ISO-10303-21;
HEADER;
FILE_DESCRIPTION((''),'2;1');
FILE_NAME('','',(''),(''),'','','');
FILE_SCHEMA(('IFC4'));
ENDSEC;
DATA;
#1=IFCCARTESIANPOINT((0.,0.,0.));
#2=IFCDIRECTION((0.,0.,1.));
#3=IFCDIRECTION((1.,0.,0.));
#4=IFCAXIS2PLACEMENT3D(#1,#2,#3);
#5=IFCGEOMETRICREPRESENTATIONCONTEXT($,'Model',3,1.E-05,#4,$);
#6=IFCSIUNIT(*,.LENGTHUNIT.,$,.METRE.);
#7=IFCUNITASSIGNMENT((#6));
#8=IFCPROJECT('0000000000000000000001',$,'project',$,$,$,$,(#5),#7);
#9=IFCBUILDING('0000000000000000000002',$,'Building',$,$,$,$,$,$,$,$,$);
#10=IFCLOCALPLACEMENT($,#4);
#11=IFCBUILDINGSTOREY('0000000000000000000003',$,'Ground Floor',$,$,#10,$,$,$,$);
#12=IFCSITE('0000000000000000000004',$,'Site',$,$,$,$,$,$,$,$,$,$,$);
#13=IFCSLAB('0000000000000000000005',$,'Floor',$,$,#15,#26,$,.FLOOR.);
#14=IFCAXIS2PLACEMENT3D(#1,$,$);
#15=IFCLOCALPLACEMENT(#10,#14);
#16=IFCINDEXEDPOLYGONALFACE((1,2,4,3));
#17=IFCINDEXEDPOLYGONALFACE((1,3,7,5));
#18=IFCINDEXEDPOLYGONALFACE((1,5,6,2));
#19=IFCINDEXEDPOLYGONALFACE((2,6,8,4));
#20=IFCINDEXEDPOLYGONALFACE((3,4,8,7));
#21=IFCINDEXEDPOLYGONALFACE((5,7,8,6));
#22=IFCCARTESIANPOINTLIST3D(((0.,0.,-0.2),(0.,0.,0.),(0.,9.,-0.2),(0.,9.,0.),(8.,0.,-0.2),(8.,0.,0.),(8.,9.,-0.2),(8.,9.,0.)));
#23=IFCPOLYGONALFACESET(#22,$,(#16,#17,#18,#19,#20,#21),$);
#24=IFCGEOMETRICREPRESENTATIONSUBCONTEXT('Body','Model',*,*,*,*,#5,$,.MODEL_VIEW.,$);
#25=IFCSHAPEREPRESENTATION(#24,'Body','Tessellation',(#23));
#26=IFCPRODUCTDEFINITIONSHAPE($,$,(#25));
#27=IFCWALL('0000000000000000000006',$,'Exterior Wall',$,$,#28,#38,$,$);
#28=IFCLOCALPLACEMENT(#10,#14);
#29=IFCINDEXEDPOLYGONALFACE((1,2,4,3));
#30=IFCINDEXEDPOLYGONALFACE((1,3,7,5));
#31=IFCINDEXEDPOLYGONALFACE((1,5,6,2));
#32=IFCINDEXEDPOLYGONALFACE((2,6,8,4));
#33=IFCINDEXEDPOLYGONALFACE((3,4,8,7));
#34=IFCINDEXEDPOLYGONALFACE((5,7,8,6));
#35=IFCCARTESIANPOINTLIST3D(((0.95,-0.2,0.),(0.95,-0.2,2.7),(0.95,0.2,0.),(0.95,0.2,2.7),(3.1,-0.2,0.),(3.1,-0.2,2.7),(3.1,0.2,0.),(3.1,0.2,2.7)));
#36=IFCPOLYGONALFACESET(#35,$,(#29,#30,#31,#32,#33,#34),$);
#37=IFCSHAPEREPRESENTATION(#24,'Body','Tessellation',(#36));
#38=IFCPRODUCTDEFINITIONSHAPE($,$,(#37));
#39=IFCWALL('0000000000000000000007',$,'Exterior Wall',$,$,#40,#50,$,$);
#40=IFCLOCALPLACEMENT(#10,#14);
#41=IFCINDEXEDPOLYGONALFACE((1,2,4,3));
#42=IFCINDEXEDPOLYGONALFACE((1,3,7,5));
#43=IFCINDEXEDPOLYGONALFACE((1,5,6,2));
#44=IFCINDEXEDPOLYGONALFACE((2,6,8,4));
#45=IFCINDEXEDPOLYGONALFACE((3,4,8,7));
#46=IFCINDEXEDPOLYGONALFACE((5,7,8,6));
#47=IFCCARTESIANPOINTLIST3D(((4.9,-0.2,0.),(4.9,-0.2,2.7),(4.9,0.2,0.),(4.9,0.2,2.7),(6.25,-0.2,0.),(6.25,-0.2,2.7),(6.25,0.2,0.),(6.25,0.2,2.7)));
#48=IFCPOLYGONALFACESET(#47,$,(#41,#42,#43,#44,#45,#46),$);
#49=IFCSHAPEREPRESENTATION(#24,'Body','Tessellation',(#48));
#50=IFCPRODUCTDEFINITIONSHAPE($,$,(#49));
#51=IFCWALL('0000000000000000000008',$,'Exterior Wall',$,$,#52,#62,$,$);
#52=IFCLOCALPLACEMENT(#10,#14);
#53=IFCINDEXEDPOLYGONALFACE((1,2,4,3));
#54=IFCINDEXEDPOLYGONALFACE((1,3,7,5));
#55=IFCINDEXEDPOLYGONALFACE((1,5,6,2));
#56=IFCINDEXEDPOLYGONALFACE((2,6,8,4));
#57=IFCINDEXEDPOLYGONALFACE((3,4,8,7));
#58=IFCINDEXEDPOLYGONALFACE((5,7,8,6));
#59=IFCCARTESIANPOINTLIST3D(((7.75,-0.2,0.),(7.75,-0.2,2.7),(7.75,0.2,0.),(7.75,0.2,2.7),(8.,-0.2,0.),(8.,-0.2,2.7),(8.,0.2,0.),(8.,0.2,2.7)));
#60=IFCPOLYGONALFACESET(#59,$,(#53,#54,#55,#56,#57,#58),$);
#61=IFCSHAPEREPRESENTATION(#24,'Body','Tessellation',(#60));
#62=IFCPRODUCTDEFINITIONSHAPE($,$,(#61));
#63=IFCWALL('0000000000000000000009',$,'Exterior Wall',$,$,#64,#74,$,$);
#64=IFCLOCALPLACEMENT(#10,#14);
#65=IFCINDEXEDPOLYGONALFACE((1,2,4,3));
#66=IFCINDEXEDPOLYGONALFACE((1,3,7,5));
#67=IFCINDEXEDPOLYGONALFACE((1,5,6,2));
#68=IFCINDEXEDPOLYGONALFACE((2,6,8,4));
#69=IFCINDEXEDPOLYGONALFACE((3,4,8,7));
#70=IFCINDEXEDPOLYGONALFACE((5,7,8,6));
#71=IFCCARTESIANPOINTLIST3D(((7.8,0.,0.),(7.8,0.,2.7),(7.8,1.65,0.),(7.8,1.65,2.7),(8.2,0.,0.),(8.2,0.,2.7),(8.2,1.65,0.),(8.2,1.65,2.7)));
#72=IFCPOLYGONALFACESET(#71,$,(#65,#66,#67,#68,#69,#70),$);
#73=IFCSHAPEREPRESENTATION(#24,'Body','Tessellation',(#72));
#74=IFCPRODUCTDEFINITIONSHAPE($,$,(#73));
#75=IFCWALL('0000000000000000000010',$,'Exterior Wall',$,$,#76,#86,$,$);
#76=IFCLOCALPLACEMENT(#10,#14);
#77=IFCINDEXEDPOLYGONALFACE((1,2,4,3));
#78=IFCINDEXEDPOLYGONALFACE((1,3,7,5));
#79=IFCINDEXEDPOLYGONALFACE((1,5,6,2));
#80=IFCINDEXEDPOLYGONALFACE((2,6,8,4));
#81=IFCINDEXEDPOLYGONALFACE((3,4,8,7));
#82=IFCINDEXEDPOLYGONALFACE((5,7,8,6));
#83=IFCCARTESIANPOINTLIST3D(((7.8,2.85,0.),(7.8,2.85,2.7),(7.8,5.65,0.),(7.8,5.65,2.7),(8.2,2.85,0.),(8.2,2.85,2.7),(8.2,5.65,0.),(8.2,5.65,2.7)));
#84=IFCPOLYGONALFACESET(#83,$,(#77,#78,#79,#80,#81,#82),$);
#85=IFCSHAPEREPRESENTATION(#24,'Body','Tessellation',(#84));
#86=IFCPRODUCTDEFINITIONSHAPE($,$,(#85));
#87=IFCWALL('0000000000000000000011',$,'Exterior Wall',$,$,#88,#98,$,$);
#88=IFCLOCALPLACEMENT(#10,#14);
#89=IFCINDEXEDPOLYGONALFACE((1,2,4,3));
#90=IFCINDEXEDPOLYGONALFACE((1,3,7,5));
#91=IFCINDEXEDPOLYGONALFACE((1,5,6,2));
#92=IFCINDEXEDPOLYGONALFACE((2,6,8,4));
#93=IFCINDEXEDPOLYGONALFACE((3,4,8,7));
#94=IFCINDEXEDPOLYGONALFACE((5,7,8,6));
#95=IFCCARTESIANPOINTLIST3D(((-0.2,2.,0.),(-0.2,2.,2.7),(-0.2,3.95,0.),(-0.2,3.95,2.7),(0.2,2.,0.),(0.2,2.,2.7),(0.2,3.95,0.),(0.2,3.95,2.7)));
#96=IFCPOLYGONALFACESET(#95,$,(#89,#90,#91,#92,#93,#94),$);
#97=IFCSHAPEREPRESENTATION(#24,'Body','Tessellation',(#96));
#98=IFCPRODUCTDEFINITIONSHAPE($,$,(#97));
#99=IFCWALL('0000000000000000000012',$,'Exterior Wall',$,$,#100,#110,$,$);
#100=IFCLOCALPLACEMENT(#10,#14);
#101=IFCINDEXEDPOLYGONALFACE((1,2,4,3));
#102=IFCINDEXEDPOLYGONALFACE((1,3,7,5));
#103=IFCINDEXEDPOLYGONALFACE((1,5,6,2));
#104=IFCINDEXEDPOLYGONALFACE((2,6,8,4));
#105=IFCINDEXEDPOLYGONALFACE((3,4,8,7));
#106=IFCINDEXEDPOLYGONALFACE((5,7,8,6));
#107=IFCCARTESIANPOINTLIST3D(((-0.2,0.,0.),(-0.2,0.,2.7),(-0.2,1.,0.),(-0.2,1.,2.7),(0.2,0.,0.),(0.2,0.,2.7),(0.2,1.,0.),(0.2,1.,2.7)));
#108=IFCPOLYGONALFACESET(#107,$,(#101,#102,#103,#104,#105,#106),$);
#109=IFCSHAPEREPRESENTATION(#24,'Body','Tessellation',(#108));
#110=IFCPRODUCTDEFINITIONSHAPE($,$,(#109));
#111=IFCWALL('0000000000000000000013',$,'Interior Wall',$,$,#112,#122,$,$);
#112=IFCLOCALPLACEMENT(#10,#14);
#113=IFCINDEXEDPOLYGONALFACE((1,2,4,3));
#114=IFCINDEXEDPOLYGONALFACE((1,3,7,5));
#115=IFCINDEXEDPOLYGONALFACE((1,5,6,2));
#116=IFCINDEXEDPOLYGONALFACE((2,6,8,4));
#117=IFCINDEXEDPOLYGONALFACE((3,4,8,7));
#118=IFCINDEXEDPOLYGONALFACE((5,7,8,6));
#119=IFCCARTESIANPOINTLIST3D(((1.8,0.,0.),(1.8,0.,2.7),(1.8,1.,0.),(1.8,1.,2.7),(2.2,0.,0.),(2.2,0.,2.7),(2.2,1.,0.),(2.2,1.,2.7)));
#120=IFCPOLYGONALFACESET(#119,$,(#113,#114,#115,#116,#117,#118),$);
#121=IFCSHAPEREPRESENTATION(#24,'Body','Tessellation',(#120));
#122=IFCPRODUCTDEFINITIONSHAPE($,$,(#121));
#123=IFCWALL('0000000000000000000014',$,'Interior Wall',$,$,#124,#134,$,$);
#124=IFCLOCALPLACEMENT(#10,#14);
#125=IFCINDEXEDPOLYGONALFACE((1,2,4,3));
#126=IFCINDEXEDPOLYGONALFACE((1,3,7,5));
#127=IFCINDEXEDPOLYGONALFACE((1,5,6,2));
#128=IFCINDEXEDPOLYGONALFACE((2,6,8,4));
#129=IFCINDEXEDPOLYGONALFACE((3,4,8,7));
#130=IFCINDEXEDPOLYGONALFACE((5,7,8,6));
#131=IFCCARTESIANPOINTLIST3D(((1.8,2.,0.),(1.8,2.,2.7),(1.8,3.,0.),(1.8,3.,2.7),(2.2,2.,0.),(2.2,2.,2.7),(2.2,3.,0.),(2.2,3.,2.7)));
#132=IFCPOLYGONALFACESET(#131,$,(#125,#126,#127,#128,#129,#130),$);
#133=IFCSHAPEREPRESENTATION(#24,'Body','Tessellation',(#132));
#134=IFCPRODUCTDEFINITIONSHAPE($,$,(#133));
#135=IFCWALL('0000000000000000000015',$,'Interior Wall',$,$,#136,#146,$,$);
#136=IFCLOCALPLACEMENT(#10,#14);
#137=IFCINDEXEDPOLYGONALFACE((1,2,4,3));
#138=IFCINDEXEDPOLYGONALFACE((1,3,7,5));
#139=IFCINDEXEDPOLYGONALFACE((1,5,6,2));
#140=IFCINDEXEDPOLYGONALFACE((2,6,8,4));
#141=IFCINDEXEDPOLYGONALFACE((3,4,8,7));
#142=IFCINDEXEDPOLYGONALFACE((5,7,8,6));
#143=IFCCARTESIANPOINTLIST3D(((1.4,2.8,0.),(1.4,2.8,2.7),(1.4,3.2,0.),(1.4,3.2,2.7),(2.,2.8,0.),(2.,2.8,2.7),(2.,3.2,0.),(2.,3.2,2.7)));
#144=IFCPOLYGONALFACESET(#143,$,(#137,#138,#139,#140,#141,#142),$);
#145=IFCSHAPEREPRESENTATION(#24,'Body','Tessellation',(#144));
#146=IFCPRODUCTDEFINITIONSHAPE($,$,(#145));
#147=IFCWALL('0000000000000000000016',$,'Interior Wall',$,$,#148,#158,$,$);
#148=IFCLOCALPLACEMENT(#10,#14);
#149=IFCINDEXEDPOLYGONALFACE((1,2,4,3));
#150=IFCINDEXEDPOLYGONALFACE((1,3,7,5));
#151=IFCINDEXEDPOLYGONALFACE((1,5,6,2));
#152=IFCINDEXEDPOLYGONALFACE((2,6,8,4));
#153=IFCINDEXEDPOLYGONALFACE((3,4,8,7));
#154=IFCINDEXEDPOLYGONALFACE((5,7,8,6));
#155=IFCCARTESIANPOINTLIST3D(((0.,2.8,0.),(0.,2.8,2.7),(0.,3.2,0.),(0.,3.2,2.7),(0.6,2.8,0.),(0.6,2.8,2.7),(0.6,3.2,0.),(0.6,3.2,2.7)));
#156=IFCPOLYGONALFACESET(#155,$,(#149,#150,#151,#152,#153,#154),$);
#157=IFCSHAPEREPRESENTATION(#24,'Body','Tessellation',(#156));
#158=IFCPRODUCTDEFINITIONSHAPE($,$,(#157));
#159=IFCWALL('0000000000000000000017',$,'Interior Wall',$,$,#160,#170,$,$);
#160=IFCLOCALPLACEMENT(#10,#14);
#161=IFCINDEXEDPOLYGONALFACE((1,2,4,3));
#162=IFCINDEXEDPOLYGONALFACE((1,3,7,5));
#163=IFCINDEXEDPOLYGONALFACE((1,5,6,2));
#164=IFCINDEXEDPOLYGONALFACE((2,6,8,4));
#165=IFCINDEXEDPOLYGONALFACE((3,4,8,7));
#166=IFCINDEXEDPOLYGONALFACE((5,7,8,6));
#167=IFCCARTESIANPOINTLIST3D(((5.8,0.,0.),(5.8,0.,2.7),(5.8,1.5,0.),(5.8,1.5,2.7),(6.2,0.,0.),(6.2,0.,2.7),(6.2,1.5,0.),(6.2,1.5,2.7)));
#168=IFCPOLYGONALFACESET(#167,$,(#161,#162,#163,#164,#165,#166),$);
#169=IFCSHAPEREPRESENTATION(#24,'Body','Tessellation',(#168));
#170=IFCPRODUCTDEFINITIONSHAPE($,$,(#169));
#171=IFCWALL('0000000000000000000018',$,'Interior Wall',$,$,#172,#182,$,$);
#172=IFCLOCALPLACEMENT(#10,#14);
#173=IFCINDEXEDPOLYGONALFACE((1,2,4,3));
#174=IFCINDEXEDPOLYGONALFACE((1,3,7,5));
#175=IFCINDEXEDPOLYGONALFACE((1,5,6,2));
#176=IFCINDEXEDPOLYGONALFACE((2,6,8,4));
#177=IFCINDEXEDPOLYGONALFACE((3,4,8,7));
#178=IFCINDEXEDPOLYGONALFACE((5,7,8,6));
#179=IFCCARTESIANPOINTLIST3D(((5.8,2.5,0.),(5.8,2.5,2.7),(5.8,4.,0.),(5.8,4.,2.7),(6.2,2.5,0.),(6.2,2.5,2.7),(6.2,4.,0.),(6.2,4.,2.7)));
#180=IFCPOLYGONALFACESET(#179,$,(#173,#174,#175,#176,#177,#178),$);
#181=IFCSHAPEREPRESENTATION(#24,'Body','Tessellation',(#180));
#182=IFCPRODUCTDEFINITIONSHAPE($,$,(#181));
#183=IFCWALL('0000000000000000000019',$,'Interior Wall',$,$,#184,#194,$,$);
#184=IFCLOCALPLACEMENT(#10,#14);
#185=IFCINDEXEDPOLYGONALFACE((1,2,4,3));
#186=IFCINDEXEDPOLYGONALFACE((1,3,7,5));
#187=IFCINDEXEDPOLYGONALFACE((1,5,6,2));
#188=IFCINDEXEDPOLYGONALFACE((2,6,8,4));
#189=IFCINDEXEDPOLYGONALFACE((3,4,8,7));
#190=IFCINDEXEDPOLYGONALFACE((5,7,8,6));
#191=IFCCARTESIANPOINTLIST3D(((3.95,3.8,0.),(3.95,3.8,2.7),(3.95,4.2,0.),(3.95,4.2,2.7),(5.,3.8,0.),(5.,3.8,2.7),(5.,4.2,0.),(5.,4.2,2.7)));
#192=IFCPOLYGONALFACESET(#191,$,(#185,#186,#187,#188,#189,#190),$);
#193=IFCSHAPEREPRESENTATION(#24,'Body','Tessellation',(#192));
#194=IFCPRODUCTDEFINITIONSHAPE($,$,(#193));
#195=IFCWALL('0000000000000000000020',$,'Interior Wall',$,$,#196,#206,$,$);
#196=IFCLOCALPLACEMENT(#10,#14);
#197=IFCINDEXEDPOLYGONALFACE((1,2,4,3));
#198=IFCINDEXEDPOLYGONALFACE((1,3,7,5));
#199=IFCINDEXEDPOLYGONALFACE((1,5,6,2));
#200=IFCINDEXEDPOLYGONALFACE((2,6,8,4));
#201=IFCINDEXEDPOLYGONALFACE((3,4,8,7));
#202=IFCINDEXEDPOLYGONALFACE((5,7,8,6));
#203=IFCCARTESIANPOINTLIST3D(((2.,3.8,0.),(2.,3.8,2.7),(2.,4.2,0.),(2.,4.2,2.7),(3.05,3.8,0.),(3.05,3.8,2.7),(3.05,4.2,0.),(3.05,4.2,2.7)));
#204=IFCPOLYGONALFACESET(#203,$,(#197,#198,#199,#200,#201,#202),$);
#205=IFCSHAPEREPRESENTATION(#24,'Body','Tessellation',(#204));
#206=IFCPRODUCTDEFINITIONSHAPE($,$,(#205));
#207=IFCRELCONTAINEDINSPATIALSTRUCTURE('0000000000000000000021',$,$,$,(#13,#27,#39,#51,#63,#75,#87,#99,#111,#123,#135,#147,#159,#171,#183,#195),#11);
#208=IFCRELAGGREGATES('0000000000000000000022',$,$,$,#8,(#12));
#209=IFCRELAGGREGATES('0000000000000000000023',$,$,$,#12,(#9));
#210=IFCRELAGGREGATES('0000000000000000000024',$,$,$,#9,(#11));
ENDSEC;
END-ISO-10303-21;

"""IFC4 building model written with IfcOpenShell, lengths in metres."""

from ifc_helpers import new_model, si_unit, frame, origin_with_axes, place, context, subcontext, project, spatial, indexed_curve, outline, extrude, element, save


model = new_model("IFC4")

# Units and contexts
model_context = context("Model", 3, precision=1e-05, world=origin_with_axes())
body_context = subcontext(model_context, "Body", "Model", "MODEL_VIEW")
ifc_project = project(units=[si_unit("LENGTHUNIT", "METRE")], contexts=[model_context])

# Site, building, storey
site = spatial("IfcSite", under=ifc_project, Name="Site")
building = spatial("IfcBuilding", under=site, Name="Building")
storey_placement = place(None, origin_with_axes())
storey = spatial("IfcBuildingStorey", under=building, at=storey_placement, Name="Ground Floor")

# Slab
slab_placement = place(storey_placement, frame((0.0, 0.0, -0.2), z_axis=(0.0, 0.0, 1.0), x_axis=(1.0, 0.0, 0.0)))
element("IfcSlab", 1, at=slab_placement, inside=storey, Name="Floor", PredefinedType="FLOOR", context=body_context, shape_type="SweptSolid", body=[
    extrude(outline(indexed_curve([(0.0, 0.0), (8.0, 0.0), (8.0, 9.0), (0.0, 9.0)])), None, (0.0, 0.0, 1.0), 0.2),
])

# Walls
wall_1_placement = place(storey_placement, frame((0.95, 0.0, 0.0), z_axis=(0.0, 0.0, 1.0), x_axis=(1.0, 0.0, 0.0)))
element("IfcWall", 2, at=wall_1_placement, inside=storey, Name="Exterior Wall", context=body_context, shape_type="SweptSolid", body=[
    extrude(outline(indexed_curve([(0.0, 0.0), (0.0, 0.4), (2.15, 0.4), (2.15, 0.0), (0.0, 0.0)], self_intersect=False)), frame((0.0, -0.2, 0.0), z_axis=(0.0, 0.0, 1.0), x_axis=(1.0, 0.0, 0.0)), (0.0, 0.0, 1.0), 2.7),
])
wall_2_placement = place(storey_placement, frame((4.9, 0.0, 0.0), z_axis=(0.0, 0.0, 1.0), x_axis=(1.0, 0.0, 0.0)))
element("IfcWall", 3, at=wall_2_placement, inside=storey, Name="Exterior Wall", context=body_context, shape_type="SweptSolid", body=[
    extrude(outline(indexed_curve([(0.0, 0.0), (0.0, 0.4), (1.35, 0.4), (1.35, 0.0), (0.0, 0.0)], self_intersect=False)), frame((0.0, -0.2, 0.0), z_axis=(0.0, 0.0, 1.0), x_axis=(1.0, 0.0, 0.0)), (0.0, 0.0, 1.0), 2.7),
])
wall_3_placement = place(storey_placement, frame((7.75, 0.0, 0.0), z_axis=(0.0, 0.0, 1.0), x_axis=(1.0, 0.0, 0.0)))
element("IfcWall", 4, at=wall_3_placement, inside=storey, Name="Exterior Wall", context=body_context, shape_type="SweptSolid", body=[
    extrude(outline(indexed_curve([(0.0, 0.0), (0.0, 0.4), (0.25, 0.4), (0.25, 0.0), (0.0, 0.0)], self_intersect=False)), frame((0.0, -0.2, 0.0), z_axis=(0.0, 0.0, 1.0), x_axis=(1.0, 0.0, 0.0)), (0.0, 0.0, 1.0), 2.7),
])
wall_4_placement = place(storey_placement, frame((8.0, 0.0, 0.0), z_axis=(0.0, 0.0, 1.0), x_axis=(0.0, 1.0, 0.0)))
element("IfcWall", 5, at=wall_4_placement, inside=storey, Name="Exterior Wall", context=body_context, shape_type="SweptSolid", body=[
    extrude(outline(indexed_curve([(0.0, 0.0), (0.0, 0.4), (1.65, 0.4), (1.65, 0.0), (0.0, 0.0)], self_intersect=False)), frame((0.0, -0.2, 0.0), z_axis=(0.0, 0.0, 1.0), x_axis=(1.0, 0.0, 0.0)), (0.0, 0.0, 1.0), 2.7),
])
wall_5_placement = place(storey_placement, frame((8.0, 2.85, 0.0), z_axis=(0.0, 0.0, 1.0), x_axis=(0.0, 1.0, 0.0)))
element("IfcWall", 6, at=wall_5_placement, inside=storey, Name="Exterior Wall", context=body_context, shape_type="SweptSolid", body=[
    extrude(outline(indexed_curve([(0.0, 0.0), (0.0, 0.4), (2.8, 0.4), (2.8, 0.0), (0.0, 0.0)], self_intersect=False)), frame((0.0, -0.2, 0.0), z_axis=(0.0, 0.0, 1.0), x_axis=(1.0, 0.0, 0.0)), (0.0, 0.0, 1.0), 2.7),
])
wall_6_placement = place(storey_placement, frame((0.0, 3.95, 0.0), z_axis=(0.0, 0.0, 1.0), x_axis=(0.0, -1.0, 0.0)))
element("IfcWall", 7, at=wall_6_placement, inside=storey, Name="Exterior Wall", context=body_context, shape_type="SweptSolid", body=[
    extrude(outline(indexed_curve([(0.0, 0.0), (0.0, 0.4), (1.95, 0.4), (1.95, 0.0), (0.0, 0.0)], self_intersect=False)), frame((0.0, -0.2, 0.0), z_axis=(0.0, 0.0, 1.0), x_axis=(1.0, 0.0, 0.0)), (0.0, 0.0, 1.0), 2.7),
])
for number, where, z_axis, x_axis, name in (
    (8, (0.0, 1.0, 0.0), (0.0, 0.0, 1.0), (0.0, -1.0, 0.0), "Exterior Wall"),
    (9, (2.0, 0.0, 0.0), (0.0, 0.0, 1.0), (0.0, 1.0, 0.0), "Interior Wall"),
    (10, (2.0, 2.0, 0.0), (0.0, 0.0, 1.0), (0.0, 1.0, 0.0), "Interior Wall"),
):
    element("IfcWall", number, at=place(storey_placement, frame(where, z_axis=z_axis, x_axis=x_axis)), inside=storey, Name=name, context=body_context, shape_type="SweptSolid", body=[
        extrude(outline(indexed_curve([(0.0, 0.0), (0.0, 0.4), (1.0, 0.4), (1.0, 0.0), (0.0, 0.0)], self_intersect=False)), frame((0.0, -0.2, 0.0), z_axis=(0.0, 0.0, 1.0), x_axis=(1.0, 0.0, 0.0)), (0.0, 0.0, 1.0), 2.7),
    ])
for number, where, z_axis, x_axis, name in (
    (11, (2.0, 3.0, 0.0), (0.0, 0.0, 1.0), (-1.0, 0.0, 0.0), "Interior Wall"),
    (12, (0.6, 3.0, 0.0), (0.0, 0.0, 1.0), (-1.0, 0.0, 0.0), "Interior Wall"),
):
    element("IfcWall", number, at=place(storey_placement, frame(where, z_axis=z_axis, x_axis=x_axis)), inside=storey, Name=name, context=body_context, shape_type="SweptSolid", body=[
        extrude(outline(indexed_curve([(0.0, 0.0), (0.0, 0.4), (0.6, 0.4), (0.6, 0.0), (0.0, 0.0)], self_intersect=False)), frame((0.0, -0.2, 0.0), z_axis=(0.0, 0.0, 1.0), x_axis=(1.0, 0.0, 0.0)), (0.0, 0.0, 1.0), 2.7),
    ])
for number, where, z_axis, x_axis, name in (
    (13, (6.0, 0.0, 0.0), (0.0, 0.0, 1.0), (0.0, 1.0, 0.0), "Interior Wall"),
    (14, (6.0, 2.5, 0.0), (0.0, 0.0, 1.0), (0.0, 1.0, 0.0), "Interior Wall"),
):
    element("IfcWall", number, at=place(storey_placement, frame(where, z_axis=z_axis, x_axis=x_axis)), inside=storey, Name=name, context=body_context, shape_type="SweptSolid", body=[
        extrude(outline(indexed_curve([(0.0, 0.0), (0.0, 0.4), (1.5, 0.4), (1.5, 0.0), (0.0, 0.0)], self_intersect=False)), frame((0.0, -0.2, 0.0), z_axis=(0.0, 0.0, 1.0), x_axis=(1.0, 0.0, 0.0)), (0.0, 0.0, 1.0), 2.7),
    ])
for number, where, z_axis, x_axis, name in (
    (15, (5.0, 4.0, 0.0), (0.0, 0.0, 1.0), (-1.0, 0.0, 0.0), "Interior Wall"),
    (16, (3.05, 4.0, 0.0), (0.0, 0.0, 1.0), (-1.0, 0.0, 0.0), "Interior Wall"),
):
    element("IfcWall", number, at=place(storey_placement, frame(where, z_axis=z_axis, x_axis=x_axis)), inside=storey, Name=name, context=body_context, shape_type="SweptSolid", body=[
        extrude(outline(indexed_curve([(0.0, 0.0), (0.0, 0.4), (1.05, 0.4), (1.05, 0.0), (0.0, 0.0)], self_intersect=False)), frame((0.0, -0.2, 0.0), z_axis=(0.0, 0.0, 1.0), x_axis=(1.0, 0.0, 0.0)), (0.0, 0.0, 1.0), 2.7),
    ])

save(model, "model.ifc")
